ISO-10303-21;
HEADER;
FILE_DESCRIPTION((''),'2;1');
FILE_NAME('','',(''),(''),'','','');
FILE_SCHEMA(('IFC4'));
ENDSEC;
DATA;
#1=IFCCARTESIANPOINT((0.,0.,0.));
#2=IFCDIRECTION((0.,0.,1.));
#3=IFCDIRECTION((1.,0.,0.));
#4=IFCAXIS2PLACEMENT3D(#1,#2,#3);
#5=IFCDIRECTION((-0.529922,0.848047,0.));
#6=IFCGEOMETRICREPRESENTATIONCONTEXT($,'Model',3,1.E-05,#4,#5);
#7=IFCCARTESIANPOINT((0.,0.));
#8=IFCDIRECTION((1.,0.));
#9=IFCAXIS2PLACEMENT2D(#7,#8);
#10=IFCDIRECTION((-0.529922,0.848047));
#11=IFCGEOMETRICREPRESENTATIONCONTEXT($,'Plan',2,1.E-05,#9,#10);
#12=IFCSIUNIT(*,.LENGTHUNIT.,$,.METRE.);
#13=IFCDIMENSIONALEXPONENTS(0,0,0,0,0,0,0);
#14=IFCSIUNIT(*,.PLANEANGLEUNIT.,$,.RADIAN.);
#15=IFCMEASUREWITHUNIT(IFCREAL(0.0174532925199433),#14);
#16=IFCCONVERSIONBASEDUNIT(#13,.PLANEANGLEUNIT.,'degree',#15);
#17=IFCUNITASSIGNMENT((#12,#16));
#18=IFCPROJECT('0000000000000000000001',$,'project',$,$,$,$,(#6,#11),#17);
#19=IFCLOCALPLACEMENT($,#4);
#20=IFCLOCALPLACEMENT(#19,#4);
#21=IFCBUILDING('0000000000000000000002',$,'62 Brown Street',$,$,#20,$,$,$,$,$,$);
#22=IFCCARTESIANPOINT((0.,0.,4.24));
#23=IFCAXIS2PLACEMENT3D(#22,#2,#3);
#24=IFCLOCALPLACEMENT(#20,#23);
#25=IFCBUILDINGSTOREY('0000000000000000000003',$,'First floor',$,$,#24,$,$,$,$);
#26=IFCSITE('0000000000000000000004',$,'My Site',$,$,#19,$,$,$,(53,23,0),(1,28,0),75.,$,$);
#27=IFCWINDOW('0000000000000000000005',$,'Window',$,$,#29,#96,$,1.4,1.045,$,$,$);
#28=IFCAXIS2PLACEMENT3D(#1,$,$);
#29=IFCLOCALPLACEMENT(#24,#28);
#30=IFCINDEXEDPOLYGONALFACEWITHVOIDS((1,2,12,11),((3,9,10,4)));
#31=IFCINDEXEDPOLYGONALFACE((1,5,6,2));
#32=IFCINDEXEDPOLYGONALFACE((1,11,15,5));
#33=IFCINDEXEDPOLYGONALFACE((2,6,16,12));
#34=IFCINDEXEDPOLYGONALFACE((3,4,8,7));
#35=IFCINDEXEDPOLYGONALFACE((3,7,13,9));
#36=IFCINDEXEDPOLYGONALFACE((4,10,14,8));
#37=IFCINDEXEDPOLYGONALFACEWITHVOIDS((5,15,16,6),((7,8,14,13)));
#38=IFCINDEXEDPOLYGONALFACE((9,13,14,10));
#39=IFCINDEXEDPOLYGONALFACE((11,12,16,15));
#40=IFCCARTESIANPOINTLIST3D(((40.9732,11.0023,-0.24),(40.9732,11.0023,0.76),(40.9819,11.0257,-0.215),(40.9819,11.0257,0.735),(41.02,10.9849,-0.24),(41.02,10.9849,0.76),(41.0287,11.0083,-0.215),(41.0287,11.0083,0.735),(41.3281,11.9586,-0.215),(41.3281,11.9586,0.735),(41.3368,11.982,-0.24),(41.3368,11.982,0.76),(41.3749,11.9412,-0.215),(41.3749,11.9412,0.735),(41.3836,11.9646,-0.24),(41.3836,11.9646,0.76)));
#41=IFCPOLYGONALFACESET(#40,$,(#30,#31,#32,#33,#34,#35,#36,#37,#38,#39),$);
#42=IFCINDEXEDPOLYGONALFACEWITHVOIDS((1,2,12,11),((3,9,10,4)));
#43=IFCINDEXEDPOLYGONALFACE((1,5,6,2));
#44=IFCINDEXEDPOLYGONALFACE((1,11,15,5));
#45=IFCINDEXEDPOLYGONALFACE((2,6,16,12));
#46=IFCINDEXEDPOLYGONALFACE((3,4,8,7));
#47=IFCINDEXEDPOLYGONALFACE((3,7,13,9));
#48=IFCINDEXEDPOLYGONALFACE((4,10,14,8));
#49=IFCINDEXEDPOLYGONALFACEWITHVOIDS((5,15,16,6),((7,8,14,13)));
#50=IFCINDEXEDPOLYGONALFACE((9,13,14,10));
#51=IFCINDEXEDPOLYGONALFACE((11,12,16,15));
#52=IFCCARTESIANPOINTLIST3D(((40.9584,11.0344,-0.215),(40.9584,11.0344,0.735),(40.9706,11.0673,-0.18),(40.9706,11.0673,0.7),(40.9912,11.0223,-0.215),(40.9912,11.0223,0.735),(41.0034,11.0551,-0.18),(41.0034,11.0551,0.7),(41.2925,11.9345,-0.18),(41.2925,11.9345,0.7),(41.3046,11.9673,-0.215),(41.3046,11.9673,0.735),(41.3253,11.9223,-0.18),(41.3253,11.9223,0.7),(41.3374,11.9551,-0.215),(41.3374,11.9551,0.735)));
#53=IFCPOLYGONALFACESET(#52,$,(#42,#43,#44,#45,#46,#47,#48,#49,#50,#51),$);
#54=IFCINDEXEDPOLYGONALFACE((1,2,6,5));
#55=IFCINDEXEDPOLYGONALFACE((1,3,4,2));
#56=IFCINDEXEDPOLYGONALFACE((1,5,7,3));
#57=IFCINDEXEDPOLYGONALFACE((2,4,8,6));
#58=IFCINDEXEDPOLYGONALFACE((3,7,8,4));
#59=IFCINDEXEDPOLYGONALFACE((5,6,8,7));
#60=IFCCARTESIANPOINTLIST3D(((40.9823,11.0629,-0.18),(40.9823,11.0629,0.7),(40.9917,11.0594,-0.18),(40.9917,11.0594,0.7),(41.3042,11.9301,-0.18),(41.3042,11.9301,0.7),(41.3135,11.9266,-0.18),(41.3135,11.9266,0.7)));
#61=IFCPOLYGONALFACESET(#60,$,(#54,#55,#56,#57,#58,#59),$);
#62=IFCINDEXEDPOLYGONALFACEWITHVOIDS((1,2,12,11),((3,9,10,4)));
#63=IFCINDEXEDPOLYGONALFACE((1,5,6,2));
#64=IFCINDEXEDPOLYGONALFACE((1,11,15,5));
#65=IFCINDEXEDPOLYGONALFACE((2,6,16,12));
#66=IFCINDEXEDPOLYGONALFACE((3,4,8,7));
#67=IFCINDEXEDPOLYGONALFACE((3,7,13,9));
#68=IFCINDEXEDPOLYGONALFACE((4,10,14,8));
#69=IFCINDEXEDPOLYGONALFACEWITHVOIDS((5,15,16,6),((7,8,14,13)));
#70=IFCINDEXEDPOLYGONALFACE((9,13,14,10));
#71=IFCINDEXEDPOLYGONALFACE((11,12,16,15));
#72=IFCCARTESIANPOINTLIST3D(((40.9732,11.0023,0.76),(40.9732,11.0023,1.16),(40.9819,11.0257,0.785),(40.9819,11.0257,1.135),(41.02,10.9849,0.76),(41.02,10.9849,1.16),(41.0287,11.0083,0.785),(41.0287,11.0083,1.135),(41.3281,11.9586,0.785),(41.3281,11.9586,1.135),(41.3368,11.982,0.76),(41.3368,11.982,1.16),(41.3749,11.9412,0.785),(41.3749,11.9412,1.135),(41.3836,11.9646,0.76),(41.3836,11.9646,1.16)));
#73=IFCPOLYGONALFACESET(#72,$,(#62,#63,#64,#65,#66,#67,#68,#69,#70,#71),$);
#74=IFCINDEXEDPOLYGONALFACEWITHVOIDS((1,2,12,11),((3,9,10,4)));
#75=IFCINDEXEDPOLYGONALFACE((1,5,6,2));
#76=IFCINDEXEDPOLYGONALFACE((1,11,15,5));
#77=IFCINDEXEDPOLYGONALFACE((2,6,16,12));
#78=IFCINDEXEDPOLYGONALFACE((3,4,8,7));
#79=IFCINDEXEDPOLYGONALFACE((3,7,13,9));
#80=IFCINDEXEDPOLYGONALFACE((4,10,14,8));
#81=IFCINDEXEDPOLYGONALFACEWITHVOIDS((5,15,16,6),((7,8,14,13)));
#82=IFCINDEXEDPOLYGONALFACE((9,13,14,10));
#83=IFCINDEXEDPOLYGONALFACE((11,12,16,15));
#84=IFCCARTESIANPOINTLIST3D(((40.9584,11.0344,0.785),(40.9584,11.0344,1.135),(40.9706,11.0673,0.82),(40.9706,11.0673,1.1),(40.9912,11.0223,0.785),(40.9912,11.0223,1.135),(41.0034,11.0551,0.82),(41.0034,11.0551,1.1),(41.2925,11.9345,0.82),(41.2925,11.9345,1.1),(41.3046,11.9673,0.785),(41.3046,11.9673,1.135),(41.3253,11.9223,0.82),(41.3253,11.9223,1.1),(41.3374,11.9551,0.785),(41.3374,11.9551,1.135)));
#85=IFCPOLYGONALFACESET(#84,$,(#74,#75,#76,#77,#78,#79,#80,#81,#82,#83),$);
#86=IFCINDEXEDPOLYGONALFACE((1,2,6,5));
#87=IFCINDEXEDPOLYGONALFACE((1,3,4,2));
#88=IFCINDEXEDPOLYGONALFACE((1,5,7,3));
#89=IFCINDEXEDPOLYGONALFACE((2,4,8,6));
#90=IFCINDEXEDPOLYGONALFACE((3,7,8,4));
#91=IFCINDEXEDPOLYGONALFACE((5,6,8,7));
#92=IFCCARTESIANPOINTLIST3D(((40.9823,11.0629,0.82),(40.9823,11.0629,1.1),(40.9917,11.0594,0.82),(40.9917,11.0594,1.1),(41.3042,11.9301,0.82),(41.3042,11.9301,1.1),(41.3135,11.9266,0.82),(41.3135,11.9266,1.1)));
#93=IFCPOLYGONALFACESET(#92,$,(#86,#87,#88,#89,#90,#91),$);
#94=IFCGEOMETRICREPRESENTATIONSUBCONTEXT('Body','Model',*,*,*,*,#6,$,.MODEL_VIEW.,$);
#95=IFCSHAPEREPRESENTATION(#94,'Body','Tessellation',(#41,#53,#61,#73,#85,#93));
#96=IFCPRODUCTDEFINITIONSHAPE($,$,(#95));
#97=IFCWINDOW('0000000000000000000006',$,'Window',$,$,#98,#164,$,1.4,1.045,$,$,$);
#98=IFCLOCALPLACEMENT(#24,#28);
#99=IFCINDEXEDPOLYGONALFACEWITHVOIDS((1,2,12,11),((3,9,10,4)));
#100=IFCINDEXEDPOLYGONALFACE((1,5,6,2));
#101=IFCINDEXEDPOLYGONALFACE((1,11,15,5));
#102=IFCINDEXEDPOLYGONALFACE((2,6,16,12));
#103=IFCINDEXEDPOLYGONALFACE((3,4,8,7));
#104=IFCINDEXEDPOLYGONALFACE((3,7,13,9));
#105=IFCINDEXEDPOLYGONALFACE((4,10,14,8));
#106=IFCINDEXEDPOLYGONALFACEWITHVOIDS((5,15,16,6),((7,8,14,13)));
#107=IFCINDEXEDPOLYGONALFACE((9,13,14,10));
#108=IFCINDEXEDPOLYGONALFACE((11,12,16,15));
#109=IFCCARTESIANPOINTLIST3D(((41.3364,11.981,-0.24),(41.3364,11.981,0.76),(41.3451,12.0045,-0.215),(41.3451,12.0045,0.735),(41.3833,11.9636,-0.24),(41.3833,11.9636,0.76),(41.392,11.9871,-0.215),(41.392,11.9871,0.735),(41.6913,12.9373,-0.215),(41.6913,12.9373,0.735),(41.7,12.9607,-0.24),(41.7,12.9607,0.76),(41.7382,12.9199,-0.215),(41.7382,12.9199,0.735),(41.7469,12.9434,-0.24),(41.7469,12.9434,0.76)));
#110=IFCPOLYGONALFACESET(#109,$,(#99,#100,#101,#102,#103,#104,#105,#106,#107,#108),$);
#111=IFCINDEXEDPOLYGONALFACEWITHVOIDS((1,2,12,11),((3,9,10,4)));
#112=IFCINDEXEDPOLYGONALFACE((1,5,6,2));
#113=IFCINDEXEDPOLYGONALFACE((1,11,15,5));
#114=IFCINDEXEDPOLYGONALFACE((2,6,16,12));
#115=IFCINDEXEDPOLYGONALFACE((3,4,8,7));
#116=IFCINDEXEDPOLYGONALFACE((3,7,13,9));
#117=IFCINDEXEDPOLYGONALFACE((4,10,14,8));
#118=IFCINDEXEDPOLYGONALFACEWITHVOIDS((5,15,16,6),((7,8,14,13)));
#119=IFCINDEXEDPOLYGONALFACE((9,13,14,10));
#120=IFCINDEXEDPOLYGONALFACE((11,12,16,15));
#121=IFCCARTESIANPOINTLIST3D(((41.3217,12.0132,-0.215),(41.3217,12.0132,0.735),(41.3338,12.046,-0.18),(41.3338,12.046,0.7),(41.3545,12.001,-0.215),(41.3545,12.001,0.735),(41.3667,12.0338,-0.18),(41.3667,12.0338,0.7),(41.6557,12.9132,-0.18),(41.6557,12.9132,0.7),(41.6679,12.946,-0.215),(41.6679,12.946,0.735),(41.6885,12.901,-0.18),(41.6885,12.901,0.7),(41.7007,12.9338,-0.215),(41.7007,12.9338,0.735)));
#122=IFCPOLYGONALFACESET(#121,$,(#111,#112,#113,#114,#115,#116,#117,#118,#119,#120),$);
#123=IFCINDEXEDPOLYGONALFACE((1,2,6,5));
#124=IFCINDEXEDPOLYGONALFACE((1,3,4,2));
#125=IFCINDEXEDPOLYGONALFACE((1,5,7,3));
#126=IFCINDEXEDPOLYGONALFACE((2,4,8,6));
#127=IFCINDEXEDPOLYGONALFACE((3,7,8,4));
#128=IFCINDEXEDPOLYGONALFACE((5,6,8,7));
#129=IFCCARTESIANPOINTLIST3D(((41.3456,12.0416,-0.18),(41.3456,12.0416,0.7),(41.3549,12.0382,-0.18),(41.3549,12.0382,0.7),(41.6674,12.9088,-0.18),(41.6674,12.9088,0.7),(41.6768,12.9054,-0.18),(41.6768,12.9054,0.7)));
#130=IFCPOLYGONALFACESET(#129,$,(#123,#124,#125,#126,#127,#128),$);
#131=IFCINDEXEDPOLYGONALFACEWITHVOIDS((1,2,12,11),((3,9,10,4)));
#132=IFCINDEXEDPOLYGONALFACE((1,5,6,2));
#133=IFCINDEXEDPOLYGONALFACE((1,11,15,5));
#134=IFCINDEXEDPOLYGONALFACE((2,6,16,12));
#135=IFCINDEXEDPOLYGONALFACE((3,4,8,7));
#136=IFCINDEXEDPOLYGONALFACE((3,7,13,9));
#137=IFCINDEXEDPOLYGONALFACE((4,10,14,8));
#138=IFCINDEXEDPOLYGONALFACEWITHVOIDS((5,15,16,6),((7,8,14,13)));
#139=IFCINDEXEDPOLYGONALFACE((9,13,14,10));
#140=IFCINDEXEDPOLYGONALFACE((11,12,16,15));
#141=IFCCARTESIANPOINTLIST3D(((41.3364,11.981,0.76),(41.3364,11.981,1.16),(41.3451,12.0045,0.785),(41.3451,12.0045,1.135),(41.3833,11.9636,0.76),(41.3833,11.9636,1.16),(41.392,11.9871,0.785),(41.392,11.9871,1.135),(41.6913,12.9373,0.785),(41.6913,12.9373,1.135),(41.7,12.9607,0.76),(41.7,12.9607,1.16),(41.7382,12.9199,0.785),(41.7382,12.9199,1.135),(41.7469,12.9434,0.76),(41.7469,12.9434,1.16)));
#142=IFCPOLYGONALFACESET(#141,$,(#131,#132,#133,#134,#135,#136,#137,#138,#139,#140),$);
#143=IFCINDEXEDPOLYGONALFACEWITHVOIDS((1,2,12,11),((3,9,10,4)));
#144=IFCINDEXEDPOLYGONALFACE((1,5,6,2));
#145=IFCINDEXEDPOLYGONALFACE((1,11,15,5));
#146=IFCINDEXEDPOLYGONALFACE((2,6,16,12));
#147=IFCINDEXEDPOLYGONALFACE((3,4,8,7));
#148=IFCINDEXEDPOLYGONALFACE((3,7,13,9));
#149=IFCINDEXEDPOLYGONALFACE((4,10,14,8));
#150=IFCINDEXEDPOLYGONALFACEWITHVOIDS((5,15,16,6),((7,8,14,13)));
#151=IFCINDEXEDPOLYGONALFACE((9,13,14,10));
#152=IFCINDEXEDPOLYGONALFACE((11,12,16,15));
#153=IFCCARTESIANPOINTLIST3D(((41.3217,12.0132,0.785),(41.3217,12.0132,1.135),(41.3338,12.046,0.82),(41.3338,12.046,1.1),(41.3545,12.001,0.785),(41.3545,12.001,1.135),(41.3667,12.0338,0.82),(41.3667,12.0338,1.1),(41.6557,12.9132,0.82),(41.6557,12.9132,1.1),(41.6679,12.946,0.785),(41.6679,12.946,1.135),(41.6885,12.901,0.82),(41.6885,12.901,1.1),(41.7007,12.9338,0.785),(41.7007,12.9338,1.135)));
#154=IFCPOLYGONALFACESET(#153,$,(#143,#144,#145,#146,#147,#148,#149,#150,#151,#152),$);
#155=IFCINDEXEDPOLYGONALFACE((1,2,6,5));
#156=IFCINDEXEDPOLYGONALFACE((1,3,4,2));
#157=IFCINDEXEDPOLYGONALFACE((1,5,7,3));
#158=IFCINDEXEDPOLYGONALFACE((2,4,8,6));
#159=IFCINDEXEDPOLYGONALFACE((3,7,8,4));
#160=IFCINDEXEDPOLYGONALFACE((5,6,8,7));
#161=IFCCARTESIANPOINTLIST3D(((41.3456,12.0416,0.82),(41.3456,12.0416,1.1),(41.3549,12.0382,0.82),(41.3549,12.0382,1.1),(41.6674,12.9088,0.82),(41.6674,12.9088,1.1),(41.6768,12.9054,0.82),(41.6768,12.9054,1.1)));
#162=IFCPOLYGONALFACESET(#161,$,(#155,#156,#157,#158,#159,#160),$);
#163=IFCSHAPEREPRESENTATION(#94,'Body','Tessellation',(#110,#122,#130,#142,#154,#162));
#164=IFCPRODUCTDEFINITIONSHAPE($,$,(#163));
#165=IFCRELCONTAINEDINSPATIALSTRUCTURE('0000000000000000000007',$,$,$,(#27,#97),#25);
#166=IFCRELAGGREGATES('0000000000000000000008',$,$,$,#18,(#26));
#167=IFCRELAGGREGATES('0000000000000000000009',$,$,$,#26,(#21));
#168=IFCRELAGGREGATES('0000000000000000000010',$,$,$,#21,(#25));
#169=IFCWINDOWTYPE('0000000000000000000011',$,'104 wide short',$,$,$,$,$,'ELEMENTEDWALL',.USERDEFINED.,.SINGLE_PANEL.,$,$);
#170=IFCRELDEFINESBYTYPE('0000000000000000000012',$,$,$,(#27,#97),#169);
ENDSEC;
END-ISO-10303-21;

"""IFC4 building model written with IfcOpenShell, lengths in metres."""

from ifc_helpers import new_model, entity, si_unit, converted_unit, direction, frame, origin_with_axes, origin_2d_with_axis, place, context, subcontext, project, spatial, line, indexed_curve, outline, extrude, shape, source, transform, mapped, type_object, type_shapes, element, save


model = new_model("IFC4")

# Units and contexts
model_context = context("Model", 3, precision=1e-05, world=origin_with_axes(), true_north=direction((-0.529922, 0.848047, 0.0)))
plan_context = context("Plan", 2, precision=1e-05, world=origin_2d_with_axis(), true_north=direction((-0.529922, 0.848047)))
body_context_1 = subcontext(model_context, "Body", "Model", "MODEL_VIEW")
body_context_2 = subcontext(plan_context, "Body", "Plan", "PLAN_VIEW")
ifc_project = project(units=[si_unit("LENGTHUNIT", "METRE"), converted_unit("PLANEANGLEUNIT", "degree", entity("IfcReal", 0.0174532925199433), si_unit("PLANEANGLEUNIT", "RADIAN"), dimensions=[0, 0, 0, 0, 0, 0, 0])], contexts=[model_context, plan_context])

# Site, building, storey
site_placement = place(None, origin_with_axes())
site = spatial("IfcSite", under=ifc_project, at=site_placement, Name="My Site", RefLatitude=(53, 23, 0), RefLongitude=(1, 28, 0), RefElevation=75.0)
building_placement = place(site_placement, origin_with_axes())
building = spatial("IfcBuilding", under=site, at=building_placement, Name="62 Brown Street")
storey_placement = place(building_placement, frame((0.0, 0.0, 4.24), z_axis=(0.0, 0.0, 1.0), x_axis=(1.0, 0.0, 0.0)))
storey = spatial("IfcBuildingStorey", under=building, at=storey_placement, Name="First floor")

# Shared definitions
window_type = type_object("IfcWindowType", Name="104 wide short", ElementType="ELEMENTEDWALL", PartitioningType="SINGLE_PANEL", PredefinedType="USERDEFINED")
shared_shape_1 = source(origin_with_axes(), body_context_1, "Body", "SweptSolid", [
    extrude(outline(indexed_curve([(0.0, 0.0), (1.045, 0.0), (1.045, 1.0), (0.0, 1.0)], segments=[line(1, 2, 3, 4, 1)]), holes=[indexed_curve([(0.025, 0.025), (1.02, 0.025), (1.02, 0.975), (0.025, 0.975)], segments=[line(1, 2, 3, 4, 1)])]), frame((0.0, 0.15, 0.0), z_axis=(0.0, -1.0, 0.0), x_axis=(1.0, 0.0, 0.0)), (0.0, 0.0, -1.0), 0.05),
    extrude(outline(indexed_curve([(0.0, 0.0), (0.995, 0.0), (0.995, 0.95), (0.0, 0.95)], segments=[line(1, 2, 3, 4, 1)]), holes=[indexed_curve([(0.035, 0.035), (0.96, 0.035), (0.96, 0.915), (0.035, 0.915)], segments=[line(1, 2, 3, 4, 1)])]), frame((0.025, 0.19, 0.025), z_axis=(0.0, -1.0, 0.0), x_axis=(1.0, 0.0, 0.0)), (0.0, 0.0, -1.0), 0.035),
    extrude(outline(indexed_curve([(0.035, 0.035), (0.96, 0.035), (0.96, 0.915), (0.035, 0.915)], segments=[line(1, 2, 3, 4, 1)])), frame((0.025, 0.2025, 0.025), z_axis=(0.0, -1.0, 0.0), x_axis=(1.0, 0.0, 0.0)), (0.0, 0.0, -1.0), 0.01),
    extrude(outline(indexed_curve([(0.0, 0.0), (1.045, 0.0), (1.045, 0.4), (0.0, 0.4)], segments=[line(1, 2, 3, 4, 1)]), holes=[indexed_curve([(0.025, 0.025), (1.02, 0.025), (1.02, 0.375), (0.025, 0.375)], segments=[line(1, 2, 3, 4, 1)])]), frame((0.0, 0.15, 1.0), z_axis=(0.0, -1.0, 0.0), x_axis=(1.0, 0.0, 0.0)), (0.0, 0.0, -1.0), 0.05),
    extrude(outline(indexed_curve([(0.0, 0.0), (0.995, 0.0), (0.995, 0.35), (0.0, 0.35)], segments=[line(1, 2, 3, 4, 1)]), holes=[indexed_curve([(0.035, 0.035), (0.96, 0.035), (0.96, 0.315), (0.035, 0.315)], segments=[line(1, 2, 3, 4, 1)])]), frame((0.025, 0.19, 1.025), z_axis=(0.0, -1.0, 0.0), x_axis=(1.0, 0.0, 0.0)), (0.0, 0.0, -1.0), 0.035),
    extrude(outline(indexed_curve([(0.035, 0.035), (0.96, 0.035), (0.96, 0.315), (0.035, 0.315)], segments=[line(1, 2, 3, 4, 1)])), frame((0.025, 0.2025, 1.025), z_axis=(0.0, -1.0, 0.0), x_axis=(1.0, 0.0, 0.0)), (0.0, 0.0, -1.0), 0.01),
])
shared_shape_2 = source(origin_with_axes(), body_context_2, "Body", "Curve2D", [
    entity("IfcIndexedPolyCurve", entity("IfcCartesianPointList2D", [[0.025, 0.15], [1.02, 0.15]])),
    entity("IfcIndexedPolyCurve", entity("IfcCartesianPointList2D", [[0.0, 0.2], [0.025, 0.2], [0.025, 0.15], [0.0, 0.15]]), [entity("IfcLineIndex", [1, 2, 3, 4, 1])]),
    entity("IfcIndexedPolyCurve", entity("IfcCartesianPointList2D", [[1.045, 0.2], [1.02, 0.2], [1.02, 0.15], [1.045, 0.15]]), [entity("IfcLineIndex", [1, 2, 3, 4, 1])]),
    entity("IfcIndexedPolyCurve", entity("IfcCartesianPointList2D", [[0.025, 0.19], [0.06, 0.19], [0.06, 0.225], [0.025, 0.225]]), [entity("IfcLineIndex", [1, 2, 3, 4, 1])]),
    entity("IfcIndexedPolyCurve", entity("IfcCartesianPointList2D", [[1.02, 0.19], [0.985, 0.19], [0.985, 0.225], [1.02, 0.225]]), [entity("IfcLineIndex", [1, 2, 3, 4, 1])]),
    entity("IfcIndexedPolyCurve", entity("IfcCartesianPointList2D", [[0.06, 0.19], [0.985, 0.19]])),
    entity("IfcIndexedPolyCurve", entity("IfcCartesianPointList2D", [[0.06, 0.225], [0.985, 0.225]])),
    entity("IfcIndexedPolyCurve", entity("IfcCartesianPointList2D", [[0.06, 0.2075], [0.985, 0.2075]])),
])
type_shapes(window_type, [shared_shape_1, shared_shape_2])

# Windows
for number, where, z_axis, x_axis, name in (
    (1, (41.1607, 10.9327, -0.24), (0.0, 0.0, 1.0), (0.347944, 0.937515, 0.0), "Window"),
    (2, (41.5239, 11.9115, -0.24), (0.0, 0.0, 1.0), (0.347944, 0.937515, 0.0), "Window"),
):
    element("IfcWindow", number, at=place(storey_placement, frame(where, z_axis=z_axis, x_axis=x_axis)), inside=storey, type_object=window_type, Name=name, OverallHeight=1.4, OverallWidth=1.045, shapes=[
        shape(body_context_1, "Body", "MappedRepresentation", [mapped(shared_shape_1, transform((0.0, 0.0, 0.0), x_axis=(1.0, 0.0, 0.0), y_axis=(0.0, 1.0, 0.0), z_axis=(0.0, 0.0, 1.0), scale=1.0))]),
        shape(body_context_2, "Body", "MappedRepresentation", [mapped(shared_shape_2, transform((0.0, 0.0, 0.0), x_axis=(1.0, 0.0, 0.0), y_axis=(0.0, 1.0, 0.0), z_axis=(0.0, 0.0, 1.0), scale=1.0))]),
    ])

save(model, "model.ifc")
